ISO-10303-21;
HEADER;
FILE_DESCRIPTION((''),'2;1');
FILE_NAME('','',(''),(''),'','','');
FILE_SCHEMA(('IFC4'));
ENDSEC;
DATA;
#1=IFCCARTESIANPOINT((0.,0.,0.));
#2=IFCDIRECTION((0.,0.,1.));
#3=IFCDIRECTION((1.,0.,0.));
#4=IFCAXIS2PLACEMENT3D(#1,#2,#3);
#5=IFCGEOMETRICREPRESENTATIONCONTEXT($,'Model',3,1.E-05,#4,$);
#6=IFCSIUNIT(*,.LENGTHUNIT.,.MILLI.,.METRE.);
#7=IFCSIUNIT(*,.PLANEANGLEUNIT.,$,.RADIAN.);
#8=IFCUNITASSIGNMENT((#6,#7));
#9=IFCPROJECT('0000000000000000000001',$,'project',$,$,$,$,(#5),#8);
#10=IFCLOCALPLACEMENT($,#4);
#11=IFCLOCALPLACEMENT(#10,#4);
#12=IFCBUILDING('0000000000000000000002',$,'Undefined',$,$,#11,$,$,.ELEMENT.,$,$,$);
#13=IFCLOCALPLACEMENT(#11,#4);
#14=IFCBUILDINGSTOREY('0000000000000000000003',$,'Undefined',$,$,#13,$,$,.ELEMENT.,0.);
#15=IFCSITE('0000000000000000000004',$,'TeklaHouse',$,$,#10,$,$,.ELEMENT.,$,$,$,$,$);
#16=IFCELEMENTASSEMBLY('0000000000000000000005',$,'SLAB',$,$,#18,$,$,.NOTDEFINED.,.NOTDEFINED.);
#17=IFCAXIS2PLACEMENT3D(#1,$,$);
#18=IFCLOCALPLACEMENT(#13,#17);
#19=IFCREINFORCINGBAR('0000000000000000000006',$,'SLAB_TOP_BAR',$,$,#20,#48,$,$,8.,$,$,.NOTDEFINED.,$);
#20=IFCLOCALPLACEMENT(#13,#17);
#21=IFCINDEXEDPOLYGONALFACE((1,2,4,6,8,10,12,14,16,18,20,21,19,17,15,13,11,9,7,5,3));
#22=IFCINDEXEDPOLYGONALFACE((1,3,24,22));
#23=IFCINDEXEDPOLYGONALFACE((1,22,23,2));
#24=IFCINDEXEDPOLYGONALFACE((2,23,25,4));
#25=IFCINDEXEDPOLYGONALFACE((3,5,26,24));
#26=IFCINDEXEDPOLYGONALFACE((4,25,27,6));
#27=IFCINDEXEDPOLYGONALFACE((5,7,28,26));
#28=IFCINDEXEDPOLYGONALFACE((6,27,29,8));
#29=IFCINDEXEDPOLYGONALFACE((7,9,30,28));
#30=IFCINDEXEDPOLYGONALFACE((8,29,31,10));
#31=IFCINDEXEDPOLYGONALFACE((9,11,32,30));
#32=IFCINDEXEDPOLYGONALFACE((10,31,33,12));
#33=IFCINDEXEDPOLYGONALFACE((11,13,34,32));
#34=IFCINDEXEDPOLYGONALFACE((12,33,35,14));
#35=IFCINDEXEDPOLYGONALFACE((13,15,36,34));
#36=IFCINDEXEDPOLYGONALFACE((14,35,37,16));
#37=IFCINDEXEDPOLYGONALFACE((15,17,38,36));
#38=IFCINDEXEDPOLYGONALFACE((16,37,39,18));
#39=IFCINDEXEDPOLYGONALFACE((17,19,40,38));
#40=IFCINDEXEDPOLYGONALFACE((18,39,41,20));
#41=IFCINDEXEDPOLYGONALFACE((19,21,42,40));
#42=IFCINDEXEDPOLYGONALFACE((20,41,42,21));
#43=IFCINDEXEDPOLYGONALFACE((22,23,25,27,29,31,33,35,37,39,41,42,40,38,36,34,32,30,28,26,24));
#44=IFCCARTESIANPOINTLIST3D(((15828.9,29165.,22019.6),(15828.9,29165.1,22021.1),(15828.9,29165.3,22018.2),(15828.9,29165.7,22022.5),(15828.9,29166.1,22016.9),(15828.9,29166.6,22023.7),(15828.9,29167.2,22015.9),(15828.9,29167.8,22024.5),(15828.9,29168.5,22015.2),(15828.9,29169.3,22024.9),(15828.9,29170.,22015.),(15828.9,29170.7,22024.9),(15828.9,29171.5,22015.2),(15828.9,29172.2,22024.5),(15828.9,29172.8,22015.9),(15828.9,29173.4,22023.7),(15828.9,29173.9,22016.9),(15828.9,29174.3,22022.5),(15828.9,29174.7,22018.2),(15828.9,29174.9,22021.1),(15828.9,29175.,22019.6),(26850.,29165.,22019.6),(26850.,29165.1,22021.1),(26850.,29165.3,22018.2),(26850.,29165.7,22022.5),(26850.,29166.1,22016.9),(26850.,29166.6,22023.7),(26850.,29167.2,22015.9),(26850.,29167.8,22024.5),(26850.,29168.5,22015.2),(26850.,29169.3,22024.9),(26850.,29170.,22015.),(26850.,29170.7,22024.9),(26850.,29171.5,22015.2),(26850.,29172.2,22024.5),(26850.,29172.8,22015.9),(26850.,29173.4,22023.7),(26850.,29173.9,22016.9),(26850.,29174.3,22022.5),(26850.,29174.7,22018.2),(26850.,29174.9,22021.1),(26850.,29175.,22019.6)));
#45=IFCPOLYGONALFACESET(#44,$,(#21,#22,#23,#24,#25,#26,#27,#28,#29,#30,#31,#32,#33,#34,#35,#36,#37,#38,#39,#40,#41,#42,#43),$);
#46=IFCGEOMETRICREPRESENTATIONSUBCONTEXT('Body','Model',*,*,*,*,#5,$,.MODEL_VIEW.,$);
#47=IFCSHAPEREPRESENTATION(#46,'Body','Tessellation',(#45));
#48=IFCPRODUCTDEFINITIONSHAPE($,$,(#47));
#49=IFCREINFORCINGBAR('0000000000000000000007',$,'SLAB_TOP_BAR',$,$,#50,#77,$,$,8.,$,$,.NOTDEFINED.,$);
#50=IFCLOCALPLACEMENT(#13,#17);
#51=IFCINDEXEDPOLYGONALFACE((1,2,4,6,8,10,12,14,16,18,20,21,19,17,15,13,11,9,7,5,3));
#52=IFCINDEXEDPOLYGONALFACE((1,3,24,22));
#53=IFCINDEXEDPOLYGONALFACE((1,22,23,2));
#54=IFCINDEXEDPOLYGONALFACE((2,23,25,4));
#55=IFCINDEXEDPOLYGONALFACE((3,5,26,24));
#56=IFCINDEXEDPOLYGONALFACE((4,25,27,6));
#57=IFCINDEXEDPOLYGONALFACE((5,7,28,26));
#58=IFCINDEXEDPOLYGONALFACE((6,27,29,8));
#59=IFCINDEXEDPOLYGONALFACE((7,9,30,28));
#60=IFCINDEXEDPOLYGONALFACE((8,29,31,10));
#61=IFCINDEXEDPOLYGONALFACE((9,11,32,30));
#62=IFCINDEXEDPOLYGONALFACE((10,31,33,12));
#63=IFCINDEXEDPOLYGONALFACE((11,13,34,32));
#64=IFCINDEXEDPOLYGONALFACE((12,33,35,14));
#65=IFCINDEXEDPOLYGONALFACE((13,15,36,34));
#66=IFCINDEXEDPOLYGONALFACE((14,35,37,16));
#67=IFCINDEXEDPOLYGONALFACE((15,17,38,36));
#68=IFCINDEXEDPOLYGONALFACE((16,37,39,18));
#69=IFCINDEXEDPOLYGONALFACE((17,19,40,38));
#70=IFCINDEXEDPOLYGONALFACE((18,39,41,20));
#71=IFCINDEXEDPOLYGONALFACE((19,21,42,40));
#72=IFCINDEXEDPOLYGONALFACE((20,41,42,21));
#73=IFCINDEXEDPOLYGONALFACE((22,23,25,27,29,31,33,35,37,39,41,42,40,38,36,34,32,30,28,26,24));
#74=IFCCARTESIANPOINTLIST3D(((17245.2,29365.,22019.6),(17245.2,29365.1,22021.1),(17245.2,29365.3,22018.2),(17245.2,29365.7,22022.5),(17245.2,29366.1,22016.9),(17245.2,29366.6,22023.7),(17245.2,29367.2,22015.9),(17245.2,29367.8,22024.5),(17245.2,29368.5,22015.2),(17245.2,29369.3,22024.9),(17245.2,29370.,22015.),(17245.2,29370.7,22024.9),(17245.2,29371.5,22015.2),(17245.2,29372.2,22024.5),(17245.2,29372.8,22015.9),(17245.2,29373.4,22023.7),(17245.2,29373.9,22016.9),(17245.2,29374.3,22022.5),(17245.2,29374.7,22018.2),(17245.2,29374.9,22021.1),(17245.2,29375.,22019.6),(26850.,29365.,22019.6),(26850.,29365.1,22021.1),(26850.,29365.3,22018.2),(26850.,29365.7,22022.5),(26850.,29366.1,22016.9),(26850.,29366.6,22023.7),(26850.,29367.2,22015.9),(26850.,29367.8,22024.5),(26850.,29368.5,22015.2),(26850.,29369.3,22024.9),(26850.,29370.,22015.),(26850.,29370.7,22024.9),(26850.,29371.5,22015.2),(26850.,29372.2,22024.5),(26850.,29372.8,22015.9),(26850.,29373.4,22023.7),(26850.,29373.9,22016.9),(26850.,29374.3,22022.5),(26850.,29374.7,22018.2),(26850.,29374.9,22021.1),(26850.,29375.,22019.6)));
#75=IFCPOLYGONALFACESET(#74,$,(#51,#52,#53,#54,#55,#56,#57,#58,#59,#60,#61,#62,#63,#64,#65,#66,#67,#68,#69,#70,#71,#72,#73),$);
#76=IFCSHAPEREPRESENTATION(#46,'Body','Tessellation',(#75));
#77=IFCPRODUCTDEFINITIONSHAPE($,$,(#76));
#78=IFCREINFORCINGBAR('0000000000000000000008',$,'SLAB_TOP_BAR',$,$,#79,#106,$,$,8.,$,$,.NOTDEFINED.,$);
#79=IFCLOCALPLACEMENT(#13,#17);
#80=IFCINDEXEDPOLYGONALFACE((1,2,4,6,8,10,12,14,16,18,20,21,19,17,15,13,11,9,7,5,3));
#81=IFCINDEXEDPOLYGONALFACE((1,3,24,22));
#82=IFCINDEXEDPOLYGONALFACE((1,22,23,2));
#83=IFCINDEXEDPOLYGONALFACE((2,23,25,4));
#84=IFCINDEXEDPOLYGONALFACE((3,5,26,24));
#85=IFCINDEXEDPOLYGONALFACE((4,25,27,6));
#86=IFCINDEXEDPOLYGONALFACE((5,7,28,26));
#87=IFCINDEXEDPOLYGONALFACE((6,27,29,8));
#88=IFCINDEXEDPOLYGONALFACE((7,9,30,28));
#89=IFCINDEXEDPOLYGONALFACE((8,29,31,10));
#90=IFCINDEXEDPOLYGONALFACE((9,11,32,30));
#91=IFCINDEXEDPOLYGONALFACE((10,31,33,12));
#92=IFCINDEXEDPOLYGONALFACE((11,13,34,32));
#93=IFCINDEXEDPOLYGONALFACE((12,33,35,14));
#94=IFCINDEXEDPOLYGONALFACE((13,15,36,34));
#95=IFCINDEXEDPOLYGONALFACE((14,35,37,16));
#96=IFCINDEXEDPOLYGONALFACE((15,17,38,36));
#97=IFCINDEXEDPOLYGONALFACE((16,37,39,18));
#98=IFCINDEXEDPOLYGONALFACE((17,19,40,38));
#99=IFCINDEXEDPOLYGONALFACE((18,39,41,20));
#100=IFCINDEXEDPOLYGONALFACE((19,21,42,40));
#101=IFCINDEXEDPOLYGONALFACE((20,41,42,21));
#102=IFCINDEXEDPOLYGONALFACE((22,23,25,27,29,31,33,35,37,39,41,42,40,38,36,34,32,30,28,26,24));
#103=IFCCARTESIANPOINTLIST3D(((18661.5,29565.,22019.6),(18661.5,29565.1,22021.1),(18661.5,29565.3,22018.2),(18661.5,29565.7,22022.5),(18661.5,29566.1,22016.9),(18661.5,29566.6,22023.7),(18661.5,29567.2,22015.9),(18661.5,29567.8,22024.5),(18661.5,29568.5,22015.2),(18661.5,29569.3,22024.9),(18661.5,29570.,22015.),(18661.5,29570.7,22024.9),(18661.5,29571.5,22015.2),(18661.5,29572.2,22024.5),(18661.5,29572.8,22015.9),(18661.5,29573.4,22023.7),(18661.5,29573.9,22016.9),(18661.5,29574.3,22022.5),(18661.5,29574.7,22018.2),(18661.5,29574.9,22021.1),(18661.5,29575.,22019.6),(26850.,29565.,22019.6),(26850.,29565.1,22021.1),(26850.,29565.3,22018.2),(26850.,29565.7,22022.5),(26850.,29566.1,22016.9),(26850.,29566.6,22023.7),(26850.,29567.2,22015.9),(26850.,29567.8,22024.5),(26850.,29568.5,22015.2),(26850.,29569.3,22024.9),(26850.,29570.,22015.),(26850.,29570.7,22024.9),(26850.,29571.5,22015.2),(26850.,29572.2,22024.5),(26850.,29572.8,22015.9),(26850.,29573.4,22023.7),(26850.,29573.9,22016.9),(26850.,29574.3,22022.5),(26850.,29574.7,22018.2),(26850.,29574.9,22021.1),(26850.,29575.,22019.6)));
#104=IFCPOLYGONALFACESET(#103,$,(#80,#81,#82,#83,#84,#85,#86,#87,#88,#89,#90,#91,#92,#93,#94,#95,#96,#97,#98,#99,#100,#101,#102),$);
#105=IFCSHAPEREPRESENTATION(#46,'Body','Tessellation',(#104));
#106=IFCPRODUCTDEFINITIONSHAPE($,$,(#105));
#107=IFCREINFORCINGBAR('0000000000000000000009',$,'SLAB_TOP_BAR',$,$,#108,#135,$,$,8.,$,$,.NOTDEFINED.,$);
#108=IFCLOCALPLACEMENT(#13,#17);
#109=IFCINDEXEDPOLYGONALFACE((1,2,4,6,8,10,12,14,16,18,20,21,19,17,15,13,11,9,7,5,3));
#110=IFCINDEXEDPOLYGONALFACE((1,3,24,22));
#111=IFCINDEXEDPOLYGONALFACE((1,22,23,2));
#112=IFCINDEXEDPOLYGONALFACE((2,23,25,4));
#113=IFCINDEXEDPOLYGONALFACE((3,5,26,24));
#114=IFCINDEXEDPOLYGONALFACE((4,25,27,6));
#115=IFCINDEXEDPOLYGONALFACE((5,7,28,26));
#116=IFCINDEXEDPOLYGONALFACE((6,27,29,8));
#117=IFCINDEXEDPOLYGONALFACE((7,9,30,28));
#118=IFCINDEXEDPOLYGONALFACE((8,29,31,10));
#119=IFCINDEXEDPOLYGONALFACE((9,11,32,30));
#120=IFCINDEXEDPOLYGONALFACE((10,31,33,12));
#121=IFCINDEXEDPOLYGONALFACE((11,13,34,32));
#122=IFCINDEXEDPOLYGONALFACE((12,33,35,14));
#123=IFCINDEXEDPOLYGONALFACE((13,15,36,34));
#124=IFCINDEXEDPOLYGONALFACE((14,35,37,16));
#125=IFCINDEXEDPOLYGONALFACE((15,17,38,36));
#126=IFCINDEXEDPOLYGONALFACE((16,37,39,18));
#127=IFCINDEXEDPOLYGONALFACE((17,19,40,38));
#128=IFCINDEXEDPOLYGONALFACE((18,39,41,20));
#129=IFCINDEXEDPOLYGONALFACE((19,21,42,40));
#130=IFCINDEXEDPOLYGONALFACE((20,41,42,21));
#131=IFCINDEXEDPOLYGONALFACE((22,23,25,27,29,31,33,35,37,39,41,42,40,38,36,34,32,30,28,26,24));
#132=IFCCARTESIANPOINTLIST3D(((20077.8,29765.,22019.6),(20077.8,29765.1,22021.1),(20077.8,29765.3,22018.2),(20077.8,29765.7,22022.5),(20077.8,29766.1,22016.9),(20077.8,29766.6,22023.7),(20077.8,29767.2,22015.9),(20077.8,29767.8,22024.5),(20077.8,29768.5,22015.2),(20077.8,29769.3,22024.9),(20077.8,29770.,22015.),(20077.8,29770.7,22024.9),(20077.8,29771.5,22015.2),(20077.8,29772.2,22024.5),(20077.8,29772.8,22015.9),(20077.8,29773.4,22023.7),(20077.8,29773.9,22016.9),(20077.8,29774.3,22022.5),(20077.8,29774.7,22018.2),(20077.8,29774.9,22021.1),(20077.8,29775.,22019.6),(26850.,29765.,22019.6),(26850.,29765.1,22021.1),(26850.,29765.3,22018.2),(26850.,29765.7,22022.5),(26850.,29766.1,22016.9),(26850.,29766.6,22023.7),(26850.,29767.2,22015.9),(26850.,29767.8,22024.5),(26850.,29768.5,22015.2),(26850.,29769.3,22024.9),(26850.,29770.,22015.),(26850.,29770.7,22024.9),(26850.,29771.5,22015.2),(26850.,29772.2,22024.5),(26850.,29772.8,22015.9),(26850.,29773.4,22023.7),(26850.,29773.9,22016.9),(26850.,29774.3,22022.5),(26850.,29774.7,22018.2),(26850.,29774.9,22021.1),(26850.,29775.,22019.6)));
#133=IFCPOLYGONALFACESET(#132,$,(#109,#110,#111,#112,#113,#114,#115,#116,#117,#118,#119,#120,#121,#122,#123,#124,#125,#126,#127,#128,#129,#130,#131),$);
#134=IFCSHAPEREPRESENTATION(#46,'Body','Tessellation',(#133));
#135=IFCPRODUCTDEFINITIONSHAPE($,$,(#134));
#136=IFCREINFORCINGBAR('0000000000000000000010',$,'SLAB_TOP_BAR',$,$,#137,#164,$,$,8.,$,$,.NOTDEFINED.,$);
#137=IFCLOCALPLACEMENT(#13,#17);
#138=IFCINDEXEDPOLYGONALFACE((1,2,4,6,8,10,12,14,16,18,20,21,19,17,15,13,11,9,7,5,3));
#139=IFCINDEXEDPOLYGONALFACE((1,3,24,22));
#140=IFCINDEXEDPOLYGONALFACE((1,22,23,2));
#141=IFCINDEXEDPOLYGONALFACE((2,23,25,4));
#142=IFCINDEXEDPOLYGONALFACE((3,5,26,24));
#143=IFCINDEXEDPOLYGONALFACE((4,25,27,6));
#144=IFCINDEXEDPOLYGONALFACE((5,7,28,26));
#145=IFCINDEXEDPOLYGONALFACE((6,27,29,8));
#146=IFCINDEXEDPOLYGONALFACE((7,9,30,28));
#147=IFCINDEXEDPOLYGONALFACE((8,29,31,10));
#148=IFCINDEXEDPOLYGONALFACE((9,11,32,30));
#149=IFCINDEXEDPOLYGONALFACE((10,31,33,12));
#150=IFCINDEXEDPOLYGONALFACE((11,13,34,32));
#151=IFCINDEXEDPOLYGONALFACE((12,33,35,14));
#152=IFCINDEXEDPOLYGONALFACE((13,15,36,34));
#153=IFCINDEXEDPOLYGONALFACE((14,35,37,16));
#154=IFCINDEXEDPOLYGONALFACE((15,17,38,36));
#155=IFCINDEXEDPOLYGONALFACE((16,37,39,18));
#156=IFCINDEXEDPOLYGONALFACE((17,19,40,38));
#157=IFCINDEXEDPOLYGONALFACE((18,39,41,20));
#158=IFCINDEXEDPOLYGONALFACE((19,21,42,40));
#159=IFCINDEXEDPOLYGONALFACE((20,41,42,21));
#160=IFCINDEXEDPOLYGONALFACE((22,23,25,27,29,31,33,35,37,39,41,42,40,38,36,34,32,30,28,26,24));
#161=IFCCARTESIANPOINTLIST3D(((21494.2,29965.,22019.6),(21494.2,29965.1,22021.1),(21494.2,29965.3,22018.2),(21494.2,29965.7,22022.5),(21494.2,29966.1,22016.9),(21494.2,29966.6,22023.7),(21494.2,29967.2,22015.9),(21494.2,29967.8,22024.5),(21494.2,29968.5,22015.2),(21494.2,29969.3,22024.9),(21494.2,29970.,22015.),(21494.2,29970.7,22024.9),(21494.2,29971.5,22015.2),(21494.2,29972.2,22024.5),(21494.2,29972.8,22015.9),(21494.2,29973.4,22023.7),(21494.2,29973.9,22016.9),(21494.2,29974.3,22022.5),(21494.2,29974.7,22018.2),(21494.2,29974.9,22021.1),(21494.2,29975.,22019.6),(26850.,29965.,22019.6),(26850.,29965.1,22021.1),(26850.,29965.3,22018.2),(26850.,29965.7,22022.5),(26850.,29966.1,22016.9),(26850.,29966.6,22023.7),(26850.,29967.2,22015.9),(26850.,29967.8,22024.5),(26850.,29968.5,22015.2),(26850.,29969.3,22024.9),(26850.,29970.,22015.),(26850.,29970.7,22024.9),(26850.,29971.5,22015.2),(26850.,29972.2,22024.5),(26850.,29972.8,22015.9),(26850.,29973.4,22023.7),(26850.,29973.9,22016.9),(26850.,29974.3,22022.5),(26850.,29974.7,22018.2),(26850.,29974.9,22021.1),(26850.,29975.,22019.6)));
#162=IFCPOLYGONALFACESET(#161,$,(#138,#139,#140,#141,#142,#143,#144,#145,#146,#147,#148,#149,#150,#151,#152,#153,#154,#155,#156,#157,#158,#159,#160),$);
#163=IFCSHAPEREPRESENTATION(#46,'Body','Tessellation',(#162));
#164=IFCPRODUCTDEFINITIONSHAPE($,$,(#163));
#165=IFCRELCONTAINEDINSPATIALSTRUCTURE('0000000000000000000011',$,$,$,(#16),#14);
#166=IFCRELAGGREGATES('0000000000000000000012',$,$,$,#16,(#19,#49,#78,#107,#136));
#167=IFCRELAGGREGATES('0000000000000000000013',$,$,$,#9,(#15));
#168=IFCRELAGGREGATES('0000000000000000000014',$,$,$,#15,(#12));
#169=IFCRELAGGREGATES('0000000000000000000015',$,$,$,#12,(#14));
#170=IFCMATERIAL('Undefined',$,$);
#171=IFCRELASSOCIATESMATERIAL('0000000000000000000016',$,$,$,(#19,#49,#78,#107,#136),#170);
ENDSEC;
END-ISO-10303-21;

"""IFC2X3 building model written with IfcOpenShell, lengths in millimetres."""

from ifc_helpers import new_model, entity, si_unit, frame, origin_with_axes, place, context, subcontext, project, spatial, source, transform, mapped, material, element, aggregate, save


model = new_model("IFC2X3")

# Units and contexts
model_context = context("Model", 3, precision=1e-05, world=origin_with_axes())
body_context = subcontext(model_context, "Body", "Model", "MODEL_VIEW")
ifc_project = project(units=[si_unit("LENGTHUNIT", "METRE", prefix="MILLI"), si_unit("PLANEANGLEUNIT", "RADIAN")], contexts=[model_context])

# Site, building, storey
site_placement = place(None, origin_with_axes())
site = spatial("IfcSite", under=ifc_project, at=site_placement, Name="TeklaHouse", CompositionType="ELEMENT")
building_placement = place(site_placement, origin_with_axes())
building = spatial("IfcBuilding", under=site, at=building_placement, Name="Undefined", CompositionType="ELEMENT")
storey_placement = place(building_placement, origin_with_axes())
storey = spatial("IfcBuildingStorey", under=building, at=storey_placement, Name="Undefined", CompositionType="ELEMENT", Elevation=0.0)

# Element assembly, reinforcing bars
assembly_1_placement = place(storey_placement, origin_with_axes())
assembly_1 = element("IfcElementAssembly", 1, at=assembly_1_placement, inside=storey, Name="SLAB", AssemblyPlace="NOTDEFINED", PredefinedType="NOTDEFINED")
ifc_material_1 = material(Name="Undefined")
shared_shape_1 = source(origin_with_axes(), body_context, "Body", "AdvancedSweptSolid", [
    entity("IfcSweptDiskSolid", entity("IfcTrimmedCurve", entity("IfcLine", entity("IfcCartesianPoint", [0.0, 0.0, 0.0]), entity("IfcVector", entity("IfcDirection", [1.0, 0.0, 0.0]), 1.0)), [entity("IfcParameterValue", 0.0)], [entity("IfcParameterValue", 11021.1384)], True, "PARAMETER"), 5.0, None, 0.0, 11021.1),
])
reinforcing_bar_1_placement = place(assembly_1_placement, frame((26850.0, 29170.0, 22020.0), z_axis=(0.0, 0.0, -1.0), x_axis=(-1.0, 0.0, 0.0)))
reinforcing_bar_1 = element("IfcReinforcingBar", 2, at=reinforcing_bar_1_placement, material=ifc_material_1, Name="SLAB_TOP_BAR", BarRole="NOTDEFINED", NominalDiameter=8.0, context=body_context, shape_type="MappedRepresentation", body=[
    mapped(shared_shape_1, transform((0.0, 0.0, 0.0))),
])
shared_shape_2 = source(origin_with_axes(), body_context, "Body", "AdvancedSweptSolid", [
    entity("IfcSweptDiskSolid", entity("IfcTrimmedCurve", entity("IfcLine", entity("IfcCartesianPoint", [0.0, 0.0, 0.0]), entity("IfcVector", entity("IfcDirection", [1.0, 0.0, 0.0]), 1.0)), [entity("IfcParameterValue", 0.0)], [entity("IfcParameterValue", 9604.813664)], True, "PARAMETER"), 5.0, None, 0.0, 9604.8),
])
reinforcing_bar_2_placement = place(assembly_1_placement, frame((26850.0, 29370.0, 22020.0), z_axis=(0.0, 0.0, -1.0), x_axis=(-1.0, 0.0, 0.0)))
reinforcing_bar_2 = element("IfcReinforcingBar", 3, at=reinforcing_bar_2_placement, material=ifc_material_1, Name="SLAB_TOP_BAR", BarRole="NOTDEFINED", NominalDiameter=8.0, context=body_context, shape_type="MappedRepresentation", body=[
    mapped(shared_shape_2, transform((0.0, 0.0, 0.0))),
])
shared_shape_3 = source(origin_with_axes(), body_context, "Body", "AdvancedSweptSolid", [
    entity("IfcSweptDiskSolid", entity("IfcTrimmedCurve", entity("IfcLine", entity("IfcCartesianPoint", [0.0, 0.0, 0.0]), entity("IfcVector", entity("IfcDirection", [1.0, 0.0, 0.0]), 1.0)), [entity("IfcParameterValue", 0.0)], [entity("IfcParameterValue", 8188.488928)], True, "PARAMETER"), 5.0, None, 0.0, 8188.5),
])
reinforcing_bar_3_placement = place(assembly_1_placement, frame((26850.0, 29570.0, 22020.0), z_axis=(0.0, 0.0, -1.0), x_axis=(-1.0, 0.0, 0.0)))
reinforcing_bar_3 = element("IfcReinforcingBar", 4, at=reinforcing_bar_3_placement, material=ifc_material_1, Name="SLAB_TOP_BAR", BarRole="NOTDEFINED", NominalDiameter=8.0, context=body_context, shape_type="MappedRepresentation", body=[
    mapped(shared_shape_3, transform((0.0, 0.0, 0.0))),
])
shared_shape_4 = source(origin_with_axes(), body_context, "Body", "AdvancedSweptSolid", [
    entity("IfcSweptDiskSolid", entity("IfcTrimmedCurve", entity("IfcLine", entity("IfcCartesianPoint", [0.0, 0.0, 0.0]), entity("IfcVector", entity("IfcDirection", [1.0, 0.0, 0.0]), 1.0)), [entity("IfcParameterValue", 0.0)], [entity("IfcParameterValue", 6772.164192)], True, "PARAMETER"), 5.0, None, 0.0, 6772.2),
])
reinforcing_bar_4_placement = place(assembly_1_placement, frame((26850.0, 29770.0, 22020.0), z_axis=(0.0, 0.0, -1.0), x_axis=(-1.0, 0.0, 0.0)))
reinforcing_bar_4 = element("IfcReinforcingBar", 5, at=reinforcing_bar_4_placement, material=ifc_material_1, Name="SLAB_TOP_BAR", BarRole="NOTDEFINED", NominalDiameter=8.0, context=body_context, shape_type="MappedRepresentation", body=[
    mapped(shared_shape_4, transform((0.0, 0.0, 0.0))),
])
shared_shape_5 = source(origin_with_axes(), body_context, "Body", "AdvancedSweptSolid", [
    entity("IfcSweptDiskSolid", entity("IfcTrimmedCurve", entity("IfcLine", entity("IfcCartesianPoint", [0.0, 0.0, 0.0]), entity("IfcVector", entity("IfcDirection", [1.0, 0.0, 0.0]), 1.0)), [entity("IfcParameterValue", 0.0)], [entity("IfcParameterValue", 5355.839456)], True, "PARAMETER"), 5.0, None, 0.0, 5355.8),
])
reinforcing_bar_5_placement = place(assembly_1_placement, frame((26850.0, 29970.0, 22020.0), z_axis=(0.0, 0.0, -1.0), x_axis=(-1.0, 0.0, 0.0)))
reinforcing_bar_5 = element("IfcReinforcingBar", 6, at=reinforcing_bar_5_placement, material=ifc_material_1, Name="SLAB_TOP_BAR", BarRole="NOTDEFINED", NominalDiameter=8.0, context=body_context, shape_type="MappedRepresentation", body=[
    mapped(shared_shape_5, transform((0.0, 0.0, 0.0))),
])
aggregate(assembly_1, [reinforcing_bar_1, reinforcing_bar_2, reinforcing_bar_3, reinforcing_bar_4, reinforcing_bar_5])

save(model, "model.ifc")
